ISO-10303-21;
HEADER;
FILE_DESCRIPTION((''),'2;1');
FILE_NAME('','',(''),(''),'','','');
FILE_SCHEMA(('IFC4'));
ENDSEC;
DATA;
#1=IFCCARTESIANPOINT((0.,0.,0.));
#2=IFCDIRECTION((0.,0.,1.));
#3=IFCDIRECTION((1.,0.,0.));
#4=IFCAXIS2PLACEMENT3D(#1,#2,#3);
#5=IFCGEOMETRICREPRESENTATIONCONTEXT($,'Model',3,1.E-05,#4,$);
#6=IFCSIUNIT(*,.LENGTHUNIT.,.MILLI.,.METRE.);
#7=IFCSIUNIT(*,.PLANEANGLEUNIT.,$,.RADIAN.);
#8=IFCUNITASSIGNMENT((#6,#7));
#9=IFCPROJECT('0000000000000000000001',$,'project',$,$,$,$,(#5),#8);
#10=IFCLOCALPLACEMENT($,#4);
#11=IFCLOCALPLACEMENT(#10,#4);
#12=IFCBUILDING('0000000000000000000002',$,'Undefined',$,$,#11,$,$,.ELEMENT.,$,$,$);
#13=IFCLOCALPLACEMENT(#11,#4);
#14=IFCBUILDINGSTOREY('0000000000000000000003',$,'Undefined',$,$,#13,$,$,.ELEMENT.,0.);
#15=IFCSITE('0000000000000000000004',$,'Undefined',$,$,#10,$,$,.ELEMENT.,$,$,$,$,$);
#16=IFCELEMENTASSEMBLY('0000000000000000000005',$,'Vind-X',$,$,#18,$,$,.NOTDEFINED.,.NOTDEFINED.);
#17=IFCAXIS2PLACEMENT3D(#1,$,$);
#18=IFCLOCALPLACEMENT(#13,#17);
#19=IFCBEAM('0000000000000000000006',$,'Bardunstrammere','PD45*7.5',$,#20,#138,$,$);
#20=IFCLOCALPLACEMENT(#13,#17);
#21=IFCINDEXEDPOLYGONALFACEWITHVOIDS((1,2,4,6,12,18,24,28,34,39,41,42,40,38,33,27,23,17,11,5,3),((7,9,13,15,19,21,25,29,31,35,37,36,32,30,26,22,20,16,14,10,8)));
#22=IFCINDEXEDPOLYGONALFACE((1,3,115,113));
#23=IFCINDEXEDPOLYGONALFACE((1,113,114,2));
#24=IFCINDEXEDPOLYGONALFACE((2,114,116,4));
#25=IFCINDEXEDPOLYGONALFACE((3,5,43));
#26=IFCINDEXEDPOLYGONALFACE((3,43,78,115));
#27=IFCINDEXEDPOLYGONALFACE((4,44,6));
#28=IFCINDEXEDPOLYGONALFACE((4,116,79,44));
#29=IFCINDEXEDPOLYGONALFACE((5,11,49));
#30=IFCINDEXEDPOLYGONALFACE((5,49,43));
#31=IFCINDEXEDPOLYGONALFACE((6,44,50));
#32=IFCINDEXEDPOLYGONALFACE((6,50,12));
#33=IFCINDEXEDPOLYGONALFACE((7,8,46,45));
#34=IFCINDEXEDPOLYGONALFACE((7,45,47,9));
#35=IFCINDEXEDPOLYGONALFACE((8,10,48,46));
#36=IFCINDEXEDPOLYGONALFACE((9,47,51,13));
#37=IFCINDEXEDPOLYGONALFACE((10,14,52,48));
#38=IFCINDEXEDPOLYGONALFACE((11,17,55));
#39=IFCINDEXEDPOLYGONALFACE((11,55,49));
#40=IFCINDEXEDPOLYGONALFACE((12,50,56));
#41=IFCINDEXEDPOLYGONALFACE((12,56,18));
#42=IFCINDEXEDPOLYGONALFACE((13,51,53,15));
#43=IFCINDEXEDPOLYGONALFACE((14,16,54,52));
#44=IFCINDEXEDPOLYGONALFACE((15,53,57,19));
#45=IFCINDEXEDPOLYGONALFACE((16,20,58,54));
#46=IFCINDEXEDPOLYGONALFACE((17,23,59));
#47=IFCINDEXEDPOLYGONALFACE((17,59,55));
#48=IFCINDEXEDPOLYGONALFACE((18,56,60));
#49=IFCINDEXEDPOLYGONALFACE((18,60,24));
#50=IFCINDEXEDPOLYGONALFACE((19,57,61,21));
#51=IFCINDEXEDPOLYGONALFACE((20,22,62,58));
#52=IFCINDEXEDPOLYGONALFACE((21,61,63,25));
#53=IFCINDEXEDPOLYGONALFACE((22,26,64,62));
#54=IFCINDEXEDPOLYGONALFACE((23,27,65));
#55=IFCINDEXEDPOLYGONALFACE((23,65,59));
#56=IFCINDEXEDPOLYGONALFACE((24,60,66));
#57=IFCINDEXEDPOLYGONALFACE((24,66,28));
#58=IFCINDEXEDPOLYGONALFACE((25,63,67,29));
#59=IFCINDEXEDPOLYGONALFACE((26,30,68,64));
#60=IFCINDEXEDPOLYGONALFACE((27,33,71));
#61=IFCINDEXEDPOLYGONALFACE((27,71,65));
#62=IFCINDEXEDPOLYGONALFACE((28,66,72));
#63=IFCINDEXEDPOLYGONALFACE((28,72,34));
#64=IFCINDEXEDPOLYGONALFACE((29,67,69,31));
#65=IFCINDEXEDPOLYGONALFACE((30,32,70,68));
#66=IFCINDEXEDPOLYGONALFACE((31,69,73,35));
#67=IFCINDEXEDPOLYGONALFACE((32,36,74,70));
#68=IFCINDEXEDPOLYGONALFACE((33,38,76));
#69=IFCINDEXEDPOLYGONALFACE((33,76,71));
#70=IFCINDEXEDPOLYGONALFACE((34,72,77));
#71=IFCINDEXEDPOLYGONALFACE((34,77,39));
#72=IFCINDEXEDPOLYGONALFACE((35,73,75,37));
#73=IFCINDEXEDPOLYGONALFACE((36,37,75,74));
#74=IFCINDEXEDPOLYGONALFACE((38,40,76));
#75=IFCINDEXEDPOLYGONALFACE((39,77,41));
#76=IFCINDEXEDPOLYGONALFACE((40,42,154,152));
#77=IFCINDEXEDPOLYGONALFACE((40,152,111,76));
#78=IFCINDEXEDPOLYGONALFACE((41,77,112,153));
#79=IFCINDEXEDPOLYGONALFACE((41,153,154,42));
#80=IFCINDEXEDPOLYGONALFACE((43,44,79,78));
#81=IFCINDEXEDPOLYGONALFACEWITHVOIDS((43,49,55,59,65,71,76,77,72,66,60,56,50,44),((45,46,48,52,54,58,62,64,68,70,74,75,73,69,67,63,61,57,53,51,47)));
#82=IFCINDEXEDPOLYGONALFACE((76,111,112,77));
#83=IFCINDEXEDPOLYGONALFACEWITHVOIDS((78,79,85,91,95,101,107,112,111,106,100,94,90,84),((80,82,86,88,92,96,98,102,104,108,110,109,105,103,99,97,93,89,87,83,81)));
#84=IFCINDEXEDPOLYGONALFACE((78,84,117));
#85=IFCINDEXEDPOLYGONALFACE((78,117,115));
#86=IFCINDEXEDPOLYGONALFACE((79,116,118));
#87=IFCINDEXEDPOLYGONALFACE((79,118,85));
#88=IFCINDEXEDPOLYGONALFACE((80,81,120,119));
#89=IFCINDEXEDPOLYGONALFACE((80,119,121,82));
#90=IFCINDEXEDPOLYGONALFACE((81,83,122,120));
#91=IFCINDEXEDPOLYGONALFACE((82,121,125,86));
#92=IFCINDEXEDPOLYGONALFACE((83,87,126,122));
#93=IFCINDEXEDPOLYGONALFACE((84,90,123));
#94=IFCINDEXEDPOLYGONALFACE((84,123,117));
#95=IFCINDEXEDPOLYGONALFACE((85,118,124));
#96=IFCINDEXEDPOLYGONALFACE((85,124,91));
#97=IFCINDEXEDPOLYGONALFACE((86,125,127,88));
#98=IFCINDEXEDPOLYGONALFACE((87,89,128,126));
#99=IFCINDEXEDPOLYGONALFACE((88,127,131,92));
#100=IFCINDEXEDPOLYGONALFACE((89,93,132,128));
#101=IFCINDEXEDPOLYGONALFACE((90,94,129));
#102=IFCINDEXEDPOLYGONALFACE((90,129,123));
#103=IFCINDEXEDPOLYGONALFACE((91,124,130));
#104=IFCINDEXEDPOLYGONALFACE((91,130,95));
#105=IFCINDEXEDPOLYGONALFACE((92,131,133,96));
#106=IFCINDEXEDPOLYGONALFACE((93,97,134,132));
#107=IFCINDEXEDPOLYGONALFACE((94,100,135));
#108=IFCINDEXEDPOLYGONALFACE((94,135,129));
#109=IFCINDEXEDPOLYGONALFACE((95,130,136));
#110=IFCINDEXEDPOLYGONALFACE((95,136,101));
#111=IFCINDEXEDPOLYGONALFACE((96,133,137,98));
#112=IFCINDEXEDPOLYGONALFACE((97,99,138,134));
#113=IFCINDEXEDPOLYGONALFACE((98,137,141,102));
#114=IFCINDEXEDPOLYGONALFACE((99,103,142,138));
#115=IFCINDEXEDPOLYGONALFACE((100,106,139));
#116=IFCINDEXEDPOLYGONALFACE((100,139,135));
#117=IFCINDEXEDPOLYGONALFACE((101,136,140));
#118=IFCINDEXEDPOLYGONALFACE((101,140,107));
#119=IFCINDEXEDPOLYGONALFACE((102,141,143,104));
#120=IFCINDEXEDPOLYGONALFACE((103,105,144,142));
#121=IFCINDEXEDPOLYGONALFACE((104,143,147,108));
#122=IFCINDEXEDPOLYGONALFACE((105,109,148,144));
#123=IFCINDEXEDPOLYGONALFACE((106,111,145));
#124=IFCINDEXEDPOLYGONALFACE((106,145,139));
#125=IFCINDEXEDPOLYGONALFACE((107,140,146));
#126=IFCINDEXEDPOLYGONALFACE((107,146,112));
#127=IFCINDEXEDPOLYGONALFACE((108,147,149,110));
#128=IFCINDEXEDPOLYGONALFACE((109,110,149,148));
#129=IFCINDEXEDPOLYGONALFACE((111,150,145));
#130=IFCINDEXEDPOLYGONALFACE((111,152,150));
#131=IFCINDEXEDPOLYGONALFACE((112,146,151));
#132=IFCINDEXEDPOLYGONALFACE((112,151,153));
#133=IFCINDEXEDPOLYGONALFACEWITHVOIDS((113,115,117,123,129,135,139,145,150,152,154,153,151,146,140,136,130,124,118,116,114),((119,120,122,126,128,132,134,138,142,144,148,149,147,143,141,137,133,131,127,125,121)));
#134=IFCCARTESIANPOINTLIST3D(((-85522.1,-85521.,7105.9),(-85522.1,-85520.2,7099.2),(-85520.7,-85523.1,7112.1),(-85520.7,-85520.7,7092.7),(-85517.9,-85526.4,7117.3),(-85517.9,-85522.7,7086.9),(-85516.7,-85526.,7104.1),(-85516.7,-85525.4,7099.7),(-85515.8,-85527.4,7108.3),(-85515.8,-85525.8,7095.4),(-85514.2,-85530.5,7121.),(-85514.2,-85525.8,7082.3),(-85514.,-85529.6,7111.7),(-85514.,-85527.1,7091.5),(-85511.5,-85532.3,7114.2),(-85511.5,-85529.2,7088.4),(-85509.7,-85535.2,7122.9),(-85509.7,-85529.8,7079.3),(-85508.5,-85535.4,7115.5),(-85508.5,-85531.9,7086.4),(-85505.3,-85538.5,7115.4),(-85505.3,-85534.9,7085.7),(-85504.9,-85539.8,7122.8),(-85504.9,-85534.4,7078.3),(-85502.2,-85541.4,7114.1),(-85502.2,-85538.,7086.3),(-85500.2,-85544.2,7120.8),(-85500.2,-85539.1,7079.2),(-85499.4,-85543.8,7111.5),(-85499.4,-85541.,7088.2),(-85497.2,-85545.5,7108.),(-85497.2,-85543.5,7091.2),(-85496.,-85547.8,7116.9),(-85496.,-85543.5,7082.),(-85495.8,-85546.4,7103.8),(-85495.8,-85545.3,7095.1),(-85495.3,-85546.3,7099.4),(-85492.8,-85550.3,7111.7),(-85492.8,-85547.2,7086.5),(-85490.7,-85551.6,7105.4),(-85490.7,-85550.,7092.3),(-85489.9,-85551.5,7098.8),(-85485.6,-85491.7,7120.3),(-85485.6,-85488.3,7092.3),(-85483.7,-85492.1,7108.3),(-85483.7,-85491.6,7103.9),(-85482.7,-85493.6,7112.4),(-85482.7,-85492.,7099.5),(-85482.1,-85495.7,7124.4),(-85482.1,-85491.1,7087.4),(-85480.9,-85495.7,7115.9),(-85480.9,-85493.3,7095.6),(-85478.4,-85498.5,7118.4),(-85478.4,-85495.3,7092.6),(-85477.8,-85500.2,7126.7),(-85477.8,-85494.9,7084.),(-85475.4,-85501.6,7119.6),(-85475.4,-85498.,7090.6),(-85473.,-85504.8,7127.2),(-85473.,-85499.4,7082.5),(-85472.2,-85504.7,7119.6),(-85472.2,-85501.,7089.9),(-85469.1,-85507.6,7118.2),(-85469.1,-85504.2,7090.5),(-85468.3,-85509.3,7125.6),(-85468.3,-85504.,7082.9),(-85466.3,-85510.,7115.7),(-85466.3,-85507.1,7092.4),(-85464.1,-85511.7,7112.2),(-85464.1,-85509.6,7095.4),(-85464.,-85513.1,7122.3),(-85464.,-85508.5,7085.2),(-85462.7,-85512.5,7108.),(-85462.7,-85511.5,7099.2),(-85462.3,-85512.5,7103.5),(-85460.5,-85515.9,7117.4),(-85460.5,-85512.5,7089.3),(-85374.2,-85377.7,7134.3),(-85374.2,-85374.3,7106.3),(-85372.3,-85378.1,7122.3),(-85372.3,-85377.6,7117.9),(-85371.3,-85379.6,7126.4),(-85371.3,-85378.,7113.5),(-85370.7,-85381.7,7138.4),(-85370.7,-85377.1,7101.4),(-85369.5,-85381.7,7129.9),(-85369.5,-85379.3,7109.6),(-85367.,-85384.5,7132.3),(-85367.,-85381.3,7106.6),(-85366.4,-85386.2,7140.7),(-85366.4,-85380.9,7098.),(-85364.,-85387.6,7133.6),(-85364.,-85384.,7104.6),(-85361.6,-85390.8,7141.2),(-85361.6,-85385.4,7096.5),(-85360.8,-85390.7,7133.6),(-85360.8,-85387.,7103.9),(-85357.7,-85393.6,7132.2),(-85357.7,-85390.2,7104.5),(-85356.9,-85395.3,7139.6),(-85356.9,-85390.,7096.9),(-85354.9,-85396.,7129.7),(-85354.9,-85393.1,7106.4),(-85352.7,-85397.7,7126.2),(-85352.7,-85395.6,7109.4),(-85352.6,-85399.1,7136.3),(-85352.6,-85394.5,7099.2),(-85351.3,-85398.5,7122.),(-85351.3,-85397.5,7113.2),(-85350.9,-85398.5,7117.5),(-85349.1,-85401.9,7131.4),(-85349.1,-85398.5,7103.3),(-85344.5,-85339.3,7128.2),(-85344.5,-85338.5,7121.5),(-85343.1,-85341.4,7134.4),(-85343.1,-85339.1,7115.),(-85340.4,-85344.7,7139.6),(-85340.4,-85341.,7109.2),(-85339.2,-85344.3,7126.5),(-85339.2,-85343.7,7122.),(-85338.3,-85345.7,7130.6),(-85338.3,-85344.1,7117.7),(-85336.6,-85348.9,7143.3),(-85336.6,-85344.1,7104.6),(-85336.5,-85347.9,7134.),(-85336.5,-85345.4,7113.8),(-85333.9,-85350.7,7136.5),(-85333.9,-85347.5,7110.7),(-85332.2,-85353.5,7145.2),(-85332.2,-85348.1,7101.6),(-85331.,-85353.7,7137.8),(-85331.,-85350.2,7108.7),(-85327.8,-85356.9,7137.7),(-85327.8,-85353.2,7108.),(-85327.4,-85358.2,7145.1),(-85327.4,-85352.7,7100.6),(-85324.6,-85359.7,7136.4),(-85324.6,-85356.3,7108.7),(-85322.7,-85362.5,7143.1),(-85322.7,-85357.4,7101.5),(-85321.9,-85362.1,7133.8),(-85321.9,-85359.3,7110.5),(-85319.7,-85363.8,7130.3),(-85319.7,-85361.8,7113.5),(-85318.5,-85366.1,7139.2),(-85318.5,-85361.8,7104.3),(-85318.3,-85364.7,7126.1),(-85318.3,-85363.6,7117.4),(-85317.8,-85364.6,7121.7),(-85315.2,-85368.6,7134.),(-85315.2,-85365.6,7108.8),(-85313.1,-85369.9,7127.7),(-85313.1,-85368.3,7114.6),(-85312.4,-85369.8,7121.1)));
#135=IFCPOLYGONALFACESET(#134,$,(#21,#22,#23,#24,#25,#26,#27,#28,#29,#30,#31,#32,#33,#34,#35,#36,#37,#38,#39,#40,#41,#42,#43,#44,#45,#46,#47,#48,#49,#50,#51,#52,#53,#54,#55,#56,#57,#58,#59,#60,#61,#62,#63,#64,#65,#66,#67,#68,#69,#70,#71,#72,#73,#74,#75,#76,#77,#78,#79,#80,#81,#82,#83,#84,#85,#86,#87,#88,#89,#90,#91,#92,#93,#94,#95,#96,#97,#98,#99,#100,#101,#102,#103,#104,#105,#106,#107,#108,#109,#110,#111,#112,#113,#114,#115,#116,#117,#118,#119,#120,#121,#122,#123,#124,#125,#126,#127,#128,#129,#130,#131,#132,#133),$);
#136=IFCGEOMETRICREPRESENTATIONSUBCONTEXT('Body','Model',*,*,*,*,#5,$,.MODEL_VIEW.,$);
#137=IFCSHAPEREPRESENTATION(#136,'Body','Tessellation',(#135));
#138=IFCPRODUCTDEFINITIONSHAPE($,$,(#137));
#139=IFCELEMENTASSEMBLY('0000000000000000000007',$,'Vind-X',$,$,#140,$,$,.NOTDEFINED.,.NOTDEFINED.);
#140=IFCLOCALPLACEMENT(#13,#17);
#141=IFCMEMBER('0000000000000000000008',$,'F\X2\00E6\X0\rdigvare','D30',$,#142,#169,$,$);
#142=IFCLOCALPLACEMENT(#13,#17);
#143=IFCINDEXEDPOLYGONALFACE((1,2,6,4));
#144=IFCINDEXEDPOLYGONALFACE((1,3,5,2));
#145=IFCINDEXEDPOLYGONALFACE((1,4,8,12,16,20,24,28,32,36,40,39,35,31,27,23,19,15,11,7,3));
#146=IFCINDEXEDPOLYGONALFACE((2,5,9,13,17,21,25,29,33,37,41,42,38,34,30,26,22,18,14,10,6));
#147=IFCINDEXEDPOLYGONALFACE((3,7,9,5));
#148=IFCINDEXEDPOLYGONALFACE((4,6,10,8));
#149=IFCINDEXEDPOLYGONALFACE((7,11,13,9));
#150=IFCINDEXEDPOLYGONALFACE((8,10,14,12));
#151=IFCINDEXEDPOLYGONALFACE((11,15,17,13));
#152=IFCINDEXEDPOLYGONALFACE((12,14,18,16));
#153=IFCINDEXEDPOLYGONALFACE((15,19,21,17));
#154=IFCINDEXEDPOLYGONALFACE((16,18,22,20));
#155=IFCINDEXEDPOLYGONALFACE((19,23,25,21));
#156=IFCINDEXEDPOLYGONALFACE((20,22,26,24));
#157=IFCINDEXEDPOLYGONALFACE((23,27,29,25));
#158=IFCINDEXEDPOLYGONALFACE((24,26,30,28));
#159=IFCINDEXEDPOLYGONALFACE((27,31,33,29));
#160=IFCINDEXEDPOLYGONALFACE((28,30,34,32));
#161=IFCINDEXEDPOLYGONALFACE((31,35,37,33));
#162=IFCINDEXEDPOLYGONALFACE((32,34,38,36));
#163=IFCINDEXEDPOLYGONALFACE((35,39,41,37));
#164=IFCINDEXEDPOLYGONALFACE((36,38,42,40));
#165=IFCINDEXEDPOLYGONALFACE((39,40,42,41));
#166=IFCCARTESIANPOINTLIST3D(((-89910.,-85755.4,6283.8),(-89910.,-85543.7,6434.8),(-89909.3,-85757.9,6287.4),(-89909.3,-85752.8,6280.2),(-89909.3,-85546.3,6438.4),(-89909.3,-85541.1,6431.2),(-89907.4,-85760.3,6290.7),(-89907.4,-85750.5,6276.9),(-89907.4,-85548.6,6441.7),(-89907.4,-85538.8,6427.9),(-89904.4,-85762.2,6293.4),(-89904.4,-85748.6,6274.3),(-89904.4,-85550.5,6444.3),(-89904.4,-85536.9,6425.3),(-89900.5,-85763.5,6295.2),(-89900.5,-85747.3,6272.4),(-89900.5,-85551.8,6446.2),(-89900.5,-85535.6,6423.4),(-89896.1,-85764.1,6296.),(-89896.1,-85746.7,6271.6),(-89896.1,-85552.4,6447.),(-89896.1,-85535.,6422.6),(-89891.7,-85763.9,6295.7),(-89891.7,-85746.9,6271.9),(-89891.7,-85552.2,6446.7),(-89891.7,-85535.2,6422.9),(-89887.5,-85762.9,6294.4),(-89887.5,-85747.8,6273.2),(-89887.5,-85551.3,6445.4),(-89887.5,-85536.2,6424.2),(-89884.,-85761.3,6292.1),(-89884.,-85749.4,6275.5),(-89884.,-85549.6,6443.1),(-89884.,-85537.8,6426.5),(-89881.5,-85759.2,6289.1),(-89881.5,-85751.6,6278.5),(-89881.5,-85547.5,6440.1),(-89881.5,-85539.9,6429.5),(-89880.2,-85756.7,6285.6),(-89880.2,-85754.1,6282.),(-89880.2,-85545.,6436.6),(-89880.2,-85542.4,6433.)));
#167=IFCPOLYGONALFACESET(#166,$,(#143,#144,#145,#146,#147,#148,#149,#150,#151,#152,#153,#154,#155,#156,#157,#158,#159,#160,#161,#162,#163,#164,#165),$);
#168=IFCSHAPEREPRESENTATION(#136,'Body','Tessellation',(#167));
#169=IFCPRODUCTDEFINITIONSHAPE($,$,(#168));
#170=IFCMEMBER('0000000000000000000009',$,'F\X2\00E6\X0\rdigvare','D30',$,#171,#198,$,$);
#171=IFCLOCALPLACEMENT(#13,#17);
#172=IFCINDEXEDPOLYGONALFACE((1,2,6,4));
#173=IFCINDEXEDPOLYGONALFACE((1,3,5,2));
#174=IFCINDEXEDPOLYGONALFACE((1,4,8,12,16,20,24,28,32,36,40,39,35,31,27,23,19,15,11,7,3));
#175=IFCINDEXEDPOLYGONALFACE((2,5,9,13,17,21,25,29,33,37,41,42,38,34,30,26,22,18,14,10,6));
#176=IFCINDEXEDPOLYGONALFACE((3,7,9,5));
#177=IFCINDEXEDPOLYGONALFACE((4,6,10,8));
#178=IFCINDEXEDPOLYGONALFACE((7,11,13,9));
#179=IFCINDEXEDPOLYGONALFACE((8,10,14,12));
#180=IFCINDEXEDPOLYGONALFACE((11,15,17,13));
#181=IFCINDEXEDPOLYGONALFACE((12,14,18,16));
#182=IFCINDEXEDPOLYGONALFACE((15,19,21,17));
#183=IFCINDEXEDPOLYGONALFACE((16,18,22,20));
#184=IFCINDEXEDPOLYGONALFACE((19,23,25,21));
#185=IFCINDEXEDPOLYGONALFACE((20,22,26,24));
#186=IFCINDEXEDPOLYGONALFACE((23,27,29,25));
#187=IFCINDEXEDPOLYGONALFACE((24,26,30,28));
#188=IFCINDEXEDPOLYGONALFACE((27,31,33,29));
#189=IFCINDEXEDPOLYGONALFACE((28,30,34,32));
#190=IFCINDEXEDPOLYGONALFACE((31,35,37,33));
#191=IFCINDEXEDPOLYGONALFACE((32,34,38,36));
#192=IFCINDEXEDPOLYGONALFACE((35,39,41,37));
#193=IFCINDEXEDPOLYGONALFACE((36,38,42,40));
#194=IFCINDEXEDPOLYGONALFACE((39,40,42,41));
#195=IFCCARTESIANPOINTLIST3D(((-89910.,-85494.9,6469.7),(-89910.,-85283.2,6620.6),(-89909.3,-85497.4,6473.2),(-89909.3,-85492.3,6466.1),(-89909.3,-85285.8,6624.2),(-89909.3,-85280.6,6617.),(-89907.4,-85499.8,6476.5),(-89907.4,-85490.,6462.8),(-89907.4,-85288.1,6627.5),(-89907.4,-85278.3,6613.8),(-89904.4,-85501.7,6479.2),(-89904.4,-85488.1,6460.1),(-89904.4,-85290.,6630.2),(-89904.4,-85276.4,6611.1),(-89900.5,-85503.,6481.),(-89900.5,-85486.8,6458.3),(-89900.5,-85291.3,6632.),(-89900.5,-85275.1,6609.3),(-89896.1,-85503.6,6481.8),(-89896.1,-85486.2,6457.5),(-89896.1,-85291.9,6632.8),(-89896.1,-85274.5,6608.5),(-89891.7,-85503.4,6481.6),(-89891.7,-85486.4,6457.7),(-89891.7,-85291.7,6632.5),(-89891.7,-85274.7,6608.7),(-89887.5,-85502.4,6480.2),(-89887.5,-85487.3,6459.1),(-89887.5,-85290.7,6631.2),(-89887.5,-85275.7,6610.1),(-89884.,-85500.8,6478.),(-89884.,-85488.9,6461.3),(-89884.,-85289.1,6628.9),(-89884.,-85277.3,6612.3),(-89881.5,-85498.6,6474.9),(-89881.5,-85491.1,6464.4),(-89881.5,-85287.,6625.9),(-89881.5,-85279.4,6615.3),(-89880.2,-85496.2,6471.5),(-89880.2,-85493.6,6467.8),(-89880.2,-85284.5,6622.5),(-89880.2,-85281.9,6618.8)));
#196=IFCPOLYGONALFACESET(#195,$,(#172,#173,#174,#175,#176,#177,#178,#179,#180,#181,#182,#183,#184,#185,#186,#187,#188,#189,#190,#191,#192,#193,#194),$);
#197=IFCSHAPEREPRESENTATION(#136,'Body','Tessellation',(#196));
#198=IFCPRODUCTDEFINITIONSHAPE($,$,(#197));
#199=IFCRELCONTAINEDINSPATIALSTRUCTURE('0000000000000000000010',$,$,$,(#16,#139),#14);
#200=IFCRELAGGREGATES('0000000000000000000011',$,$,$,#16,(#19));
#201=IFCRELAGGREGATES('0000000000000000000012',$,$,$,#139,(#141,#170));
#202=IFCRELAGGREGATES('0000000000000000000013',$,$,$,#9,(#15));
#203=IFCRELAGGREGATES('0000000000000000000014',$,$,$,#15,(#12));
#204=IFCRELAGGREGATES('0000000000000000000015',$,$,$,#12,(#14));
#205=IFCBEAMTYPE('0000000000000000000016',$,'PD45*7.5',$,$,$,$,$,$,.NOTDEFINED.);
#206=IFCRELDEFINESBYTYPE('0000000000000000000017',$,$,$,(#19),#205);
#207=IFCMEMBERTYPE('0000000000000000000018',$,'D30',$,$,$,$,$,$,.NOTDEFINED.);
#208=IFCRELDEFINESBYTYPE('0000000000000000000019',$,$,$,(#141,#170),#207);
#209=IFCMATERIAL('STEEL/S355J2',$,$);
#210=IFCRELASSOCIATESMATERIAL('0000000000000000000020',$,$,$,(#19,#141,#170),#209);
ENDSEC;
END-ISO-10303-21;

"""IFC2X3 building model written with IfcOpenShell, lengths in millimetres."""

from ifc_helpers import new_model, si_unit, frame, origin_with_axes, origin_2d_with_axis, place, context, subcontext, project, spatial, rectangle, circle, hollow_circle, extrude, boolean, material, type_object, element, aggregate, save


model = new_model("IFC2X3")

# Units and contexts
model_context = context("Model", 3, precision=1e-05, world=origin_with_axes())
body_context = subcontext(model_context, "Body", "Model", "MODEL_VIEW")
ifc_project = project(units=[si_unit("LENGTHUNIT", "METRE", prefix="MILLI"), si_unit("PLANEANGLEUNIT", "RADIAN")], contexts=[model_context])

# Site, building, storey
site_placement = place(None, origin_with_axes())
site = spatial("IfcSite", under=ifc_project, at=site_placement, Name="Undefined", CompositionType="ELEMENT")
building_placement = place(site_placement, origin_with_axes())
building = spatial("IfcBuilding", under=site, at=building_placement, Name="Undefined", CompositionType="ELEMENT")
storey_placement = place(building_placement, origin_with_axes())
storey = spatial("IfcBuildingStorey", under=building, at=storey_placement, Name="Undefined", CompositionType="ELEMENT", Elevation=0.0)

# Element assembly, beam
assembly_1_placement = place(storey_placement, origin_with_axes())
assembly_1 = element("IfcElementAssembly", 1, at=assembly_1_placement, inside=storey, Name="Vind-X", AssemblyPlace="NOTDEFINED", PredefinedType="NOTDEFINED")
ifc_material_1 = material(Name="STEEL/S355J2")
beam_type_1 = type_object("IfcBeamType", Name="PD45*7.5", PredefinedType="NOTDEFINED")
beam_1_placement = place(assembly_1_placement, frame((-85328.6, -85354.3, 7123.0), z_axis=(0.0, 0.121869, -0.992546), x_axis=(-0.696206, -0.712491, -0.087483)))
beam_1 = element("IfcBeam", 2, at=beam_1_placement, type_object=beam_type_1, material=ifc_material_1, Name="Bardunstrammere", Description="PD45*7.5", context=body_context, shape_type="CSG", body=[
    boolean("DIFFERENCE", extrude(hollow_circle(Radius=22.5, WallThickness=7.5, at=origin_2d_with_axis()), frame((255.0, 0.0, 0.0), z_axis=(-1.0, 0.0, 0.0), x_axis=(0.0, -1.0, 0.0)), (0.0, 0.0, 1.0), 255.0), extrude(rectangle(XDim=35.0, YDim=90.0, at=origin_2d_with_axis()), frame((207.5, 0.0, 0.0), z_axis=(-1.0, 0.0, 0.0), x_axis=(0.0, -1.0, 0.0)), (0.0, 0.0, 1.0), 160.0)),
])

# Shared definitions
member_type_1 = type_object("IfcMemberType", Name="D30", PredefinedType="NOTDEFINED")

# Element assembly, members
assembly_2_placement = place(storey_placement, origin_with_axes())
assembly_2 = element("IfcElementAssembly", 3, at=assembly_2_placement, inside=storey, Name="Vind-X", AssemblyPlace="NOTDEFINED", PredefinedType="NOTDEFINED")
member_1_placement = place(assembly_2_placement, frame((-89895.0, -85543.7, 6434.8), z_axis=(0.0, -0.580739, 0.814089), x_axis=(0.0, -0.814089, -0.580739)))
member_1 = element("IfcMember", 4, at=member_1_placement, type_object=member_type_1, material=ifc_material_1, Name="Færdigvare", Description="D30", context=body_context, shape_type="SweptSolid", body=[
    extrude(circle(Radius=15.0, at=origin_2d_with_axis()), frame((260.0, 0.0, 0.0), z_axis=(-1.0, 0.0, 0.0), x_axis=(0.0, -1.0, 0.0)), (0.0, 0.0, 1.0), 260.0),
])
member_2_placement = place(assembly_2_placement, frame((-89895.0, -85283.2, 6620.6), z_axis=(0.0, -0.58074, 0.814089), x_axis=(0.0, -0.814089, -0.58074)))
member_2 = element("IfcMember", 5, at=member_2_placement, type_object=member_type_1, material=ifc_material_1, Name="Færdigvare", Description="D30", context=body_context, shape_type="SweptSolid", body=[
    extrude(circle(Radius=15.0, at=origin_2d_with_axis()), frame((260.0, 0.0, 0.0), z_axis=(-1.0, 0.0, 0.0), x_axis=(0.0, -1.0, 0.0)), (0.0, 0.0, 1.0), 260.0),
])

aggregate(assembly_1, [beam_1])

aggregate(assembly_2, [member_1, member_2])

save(model, "model.ifc")
